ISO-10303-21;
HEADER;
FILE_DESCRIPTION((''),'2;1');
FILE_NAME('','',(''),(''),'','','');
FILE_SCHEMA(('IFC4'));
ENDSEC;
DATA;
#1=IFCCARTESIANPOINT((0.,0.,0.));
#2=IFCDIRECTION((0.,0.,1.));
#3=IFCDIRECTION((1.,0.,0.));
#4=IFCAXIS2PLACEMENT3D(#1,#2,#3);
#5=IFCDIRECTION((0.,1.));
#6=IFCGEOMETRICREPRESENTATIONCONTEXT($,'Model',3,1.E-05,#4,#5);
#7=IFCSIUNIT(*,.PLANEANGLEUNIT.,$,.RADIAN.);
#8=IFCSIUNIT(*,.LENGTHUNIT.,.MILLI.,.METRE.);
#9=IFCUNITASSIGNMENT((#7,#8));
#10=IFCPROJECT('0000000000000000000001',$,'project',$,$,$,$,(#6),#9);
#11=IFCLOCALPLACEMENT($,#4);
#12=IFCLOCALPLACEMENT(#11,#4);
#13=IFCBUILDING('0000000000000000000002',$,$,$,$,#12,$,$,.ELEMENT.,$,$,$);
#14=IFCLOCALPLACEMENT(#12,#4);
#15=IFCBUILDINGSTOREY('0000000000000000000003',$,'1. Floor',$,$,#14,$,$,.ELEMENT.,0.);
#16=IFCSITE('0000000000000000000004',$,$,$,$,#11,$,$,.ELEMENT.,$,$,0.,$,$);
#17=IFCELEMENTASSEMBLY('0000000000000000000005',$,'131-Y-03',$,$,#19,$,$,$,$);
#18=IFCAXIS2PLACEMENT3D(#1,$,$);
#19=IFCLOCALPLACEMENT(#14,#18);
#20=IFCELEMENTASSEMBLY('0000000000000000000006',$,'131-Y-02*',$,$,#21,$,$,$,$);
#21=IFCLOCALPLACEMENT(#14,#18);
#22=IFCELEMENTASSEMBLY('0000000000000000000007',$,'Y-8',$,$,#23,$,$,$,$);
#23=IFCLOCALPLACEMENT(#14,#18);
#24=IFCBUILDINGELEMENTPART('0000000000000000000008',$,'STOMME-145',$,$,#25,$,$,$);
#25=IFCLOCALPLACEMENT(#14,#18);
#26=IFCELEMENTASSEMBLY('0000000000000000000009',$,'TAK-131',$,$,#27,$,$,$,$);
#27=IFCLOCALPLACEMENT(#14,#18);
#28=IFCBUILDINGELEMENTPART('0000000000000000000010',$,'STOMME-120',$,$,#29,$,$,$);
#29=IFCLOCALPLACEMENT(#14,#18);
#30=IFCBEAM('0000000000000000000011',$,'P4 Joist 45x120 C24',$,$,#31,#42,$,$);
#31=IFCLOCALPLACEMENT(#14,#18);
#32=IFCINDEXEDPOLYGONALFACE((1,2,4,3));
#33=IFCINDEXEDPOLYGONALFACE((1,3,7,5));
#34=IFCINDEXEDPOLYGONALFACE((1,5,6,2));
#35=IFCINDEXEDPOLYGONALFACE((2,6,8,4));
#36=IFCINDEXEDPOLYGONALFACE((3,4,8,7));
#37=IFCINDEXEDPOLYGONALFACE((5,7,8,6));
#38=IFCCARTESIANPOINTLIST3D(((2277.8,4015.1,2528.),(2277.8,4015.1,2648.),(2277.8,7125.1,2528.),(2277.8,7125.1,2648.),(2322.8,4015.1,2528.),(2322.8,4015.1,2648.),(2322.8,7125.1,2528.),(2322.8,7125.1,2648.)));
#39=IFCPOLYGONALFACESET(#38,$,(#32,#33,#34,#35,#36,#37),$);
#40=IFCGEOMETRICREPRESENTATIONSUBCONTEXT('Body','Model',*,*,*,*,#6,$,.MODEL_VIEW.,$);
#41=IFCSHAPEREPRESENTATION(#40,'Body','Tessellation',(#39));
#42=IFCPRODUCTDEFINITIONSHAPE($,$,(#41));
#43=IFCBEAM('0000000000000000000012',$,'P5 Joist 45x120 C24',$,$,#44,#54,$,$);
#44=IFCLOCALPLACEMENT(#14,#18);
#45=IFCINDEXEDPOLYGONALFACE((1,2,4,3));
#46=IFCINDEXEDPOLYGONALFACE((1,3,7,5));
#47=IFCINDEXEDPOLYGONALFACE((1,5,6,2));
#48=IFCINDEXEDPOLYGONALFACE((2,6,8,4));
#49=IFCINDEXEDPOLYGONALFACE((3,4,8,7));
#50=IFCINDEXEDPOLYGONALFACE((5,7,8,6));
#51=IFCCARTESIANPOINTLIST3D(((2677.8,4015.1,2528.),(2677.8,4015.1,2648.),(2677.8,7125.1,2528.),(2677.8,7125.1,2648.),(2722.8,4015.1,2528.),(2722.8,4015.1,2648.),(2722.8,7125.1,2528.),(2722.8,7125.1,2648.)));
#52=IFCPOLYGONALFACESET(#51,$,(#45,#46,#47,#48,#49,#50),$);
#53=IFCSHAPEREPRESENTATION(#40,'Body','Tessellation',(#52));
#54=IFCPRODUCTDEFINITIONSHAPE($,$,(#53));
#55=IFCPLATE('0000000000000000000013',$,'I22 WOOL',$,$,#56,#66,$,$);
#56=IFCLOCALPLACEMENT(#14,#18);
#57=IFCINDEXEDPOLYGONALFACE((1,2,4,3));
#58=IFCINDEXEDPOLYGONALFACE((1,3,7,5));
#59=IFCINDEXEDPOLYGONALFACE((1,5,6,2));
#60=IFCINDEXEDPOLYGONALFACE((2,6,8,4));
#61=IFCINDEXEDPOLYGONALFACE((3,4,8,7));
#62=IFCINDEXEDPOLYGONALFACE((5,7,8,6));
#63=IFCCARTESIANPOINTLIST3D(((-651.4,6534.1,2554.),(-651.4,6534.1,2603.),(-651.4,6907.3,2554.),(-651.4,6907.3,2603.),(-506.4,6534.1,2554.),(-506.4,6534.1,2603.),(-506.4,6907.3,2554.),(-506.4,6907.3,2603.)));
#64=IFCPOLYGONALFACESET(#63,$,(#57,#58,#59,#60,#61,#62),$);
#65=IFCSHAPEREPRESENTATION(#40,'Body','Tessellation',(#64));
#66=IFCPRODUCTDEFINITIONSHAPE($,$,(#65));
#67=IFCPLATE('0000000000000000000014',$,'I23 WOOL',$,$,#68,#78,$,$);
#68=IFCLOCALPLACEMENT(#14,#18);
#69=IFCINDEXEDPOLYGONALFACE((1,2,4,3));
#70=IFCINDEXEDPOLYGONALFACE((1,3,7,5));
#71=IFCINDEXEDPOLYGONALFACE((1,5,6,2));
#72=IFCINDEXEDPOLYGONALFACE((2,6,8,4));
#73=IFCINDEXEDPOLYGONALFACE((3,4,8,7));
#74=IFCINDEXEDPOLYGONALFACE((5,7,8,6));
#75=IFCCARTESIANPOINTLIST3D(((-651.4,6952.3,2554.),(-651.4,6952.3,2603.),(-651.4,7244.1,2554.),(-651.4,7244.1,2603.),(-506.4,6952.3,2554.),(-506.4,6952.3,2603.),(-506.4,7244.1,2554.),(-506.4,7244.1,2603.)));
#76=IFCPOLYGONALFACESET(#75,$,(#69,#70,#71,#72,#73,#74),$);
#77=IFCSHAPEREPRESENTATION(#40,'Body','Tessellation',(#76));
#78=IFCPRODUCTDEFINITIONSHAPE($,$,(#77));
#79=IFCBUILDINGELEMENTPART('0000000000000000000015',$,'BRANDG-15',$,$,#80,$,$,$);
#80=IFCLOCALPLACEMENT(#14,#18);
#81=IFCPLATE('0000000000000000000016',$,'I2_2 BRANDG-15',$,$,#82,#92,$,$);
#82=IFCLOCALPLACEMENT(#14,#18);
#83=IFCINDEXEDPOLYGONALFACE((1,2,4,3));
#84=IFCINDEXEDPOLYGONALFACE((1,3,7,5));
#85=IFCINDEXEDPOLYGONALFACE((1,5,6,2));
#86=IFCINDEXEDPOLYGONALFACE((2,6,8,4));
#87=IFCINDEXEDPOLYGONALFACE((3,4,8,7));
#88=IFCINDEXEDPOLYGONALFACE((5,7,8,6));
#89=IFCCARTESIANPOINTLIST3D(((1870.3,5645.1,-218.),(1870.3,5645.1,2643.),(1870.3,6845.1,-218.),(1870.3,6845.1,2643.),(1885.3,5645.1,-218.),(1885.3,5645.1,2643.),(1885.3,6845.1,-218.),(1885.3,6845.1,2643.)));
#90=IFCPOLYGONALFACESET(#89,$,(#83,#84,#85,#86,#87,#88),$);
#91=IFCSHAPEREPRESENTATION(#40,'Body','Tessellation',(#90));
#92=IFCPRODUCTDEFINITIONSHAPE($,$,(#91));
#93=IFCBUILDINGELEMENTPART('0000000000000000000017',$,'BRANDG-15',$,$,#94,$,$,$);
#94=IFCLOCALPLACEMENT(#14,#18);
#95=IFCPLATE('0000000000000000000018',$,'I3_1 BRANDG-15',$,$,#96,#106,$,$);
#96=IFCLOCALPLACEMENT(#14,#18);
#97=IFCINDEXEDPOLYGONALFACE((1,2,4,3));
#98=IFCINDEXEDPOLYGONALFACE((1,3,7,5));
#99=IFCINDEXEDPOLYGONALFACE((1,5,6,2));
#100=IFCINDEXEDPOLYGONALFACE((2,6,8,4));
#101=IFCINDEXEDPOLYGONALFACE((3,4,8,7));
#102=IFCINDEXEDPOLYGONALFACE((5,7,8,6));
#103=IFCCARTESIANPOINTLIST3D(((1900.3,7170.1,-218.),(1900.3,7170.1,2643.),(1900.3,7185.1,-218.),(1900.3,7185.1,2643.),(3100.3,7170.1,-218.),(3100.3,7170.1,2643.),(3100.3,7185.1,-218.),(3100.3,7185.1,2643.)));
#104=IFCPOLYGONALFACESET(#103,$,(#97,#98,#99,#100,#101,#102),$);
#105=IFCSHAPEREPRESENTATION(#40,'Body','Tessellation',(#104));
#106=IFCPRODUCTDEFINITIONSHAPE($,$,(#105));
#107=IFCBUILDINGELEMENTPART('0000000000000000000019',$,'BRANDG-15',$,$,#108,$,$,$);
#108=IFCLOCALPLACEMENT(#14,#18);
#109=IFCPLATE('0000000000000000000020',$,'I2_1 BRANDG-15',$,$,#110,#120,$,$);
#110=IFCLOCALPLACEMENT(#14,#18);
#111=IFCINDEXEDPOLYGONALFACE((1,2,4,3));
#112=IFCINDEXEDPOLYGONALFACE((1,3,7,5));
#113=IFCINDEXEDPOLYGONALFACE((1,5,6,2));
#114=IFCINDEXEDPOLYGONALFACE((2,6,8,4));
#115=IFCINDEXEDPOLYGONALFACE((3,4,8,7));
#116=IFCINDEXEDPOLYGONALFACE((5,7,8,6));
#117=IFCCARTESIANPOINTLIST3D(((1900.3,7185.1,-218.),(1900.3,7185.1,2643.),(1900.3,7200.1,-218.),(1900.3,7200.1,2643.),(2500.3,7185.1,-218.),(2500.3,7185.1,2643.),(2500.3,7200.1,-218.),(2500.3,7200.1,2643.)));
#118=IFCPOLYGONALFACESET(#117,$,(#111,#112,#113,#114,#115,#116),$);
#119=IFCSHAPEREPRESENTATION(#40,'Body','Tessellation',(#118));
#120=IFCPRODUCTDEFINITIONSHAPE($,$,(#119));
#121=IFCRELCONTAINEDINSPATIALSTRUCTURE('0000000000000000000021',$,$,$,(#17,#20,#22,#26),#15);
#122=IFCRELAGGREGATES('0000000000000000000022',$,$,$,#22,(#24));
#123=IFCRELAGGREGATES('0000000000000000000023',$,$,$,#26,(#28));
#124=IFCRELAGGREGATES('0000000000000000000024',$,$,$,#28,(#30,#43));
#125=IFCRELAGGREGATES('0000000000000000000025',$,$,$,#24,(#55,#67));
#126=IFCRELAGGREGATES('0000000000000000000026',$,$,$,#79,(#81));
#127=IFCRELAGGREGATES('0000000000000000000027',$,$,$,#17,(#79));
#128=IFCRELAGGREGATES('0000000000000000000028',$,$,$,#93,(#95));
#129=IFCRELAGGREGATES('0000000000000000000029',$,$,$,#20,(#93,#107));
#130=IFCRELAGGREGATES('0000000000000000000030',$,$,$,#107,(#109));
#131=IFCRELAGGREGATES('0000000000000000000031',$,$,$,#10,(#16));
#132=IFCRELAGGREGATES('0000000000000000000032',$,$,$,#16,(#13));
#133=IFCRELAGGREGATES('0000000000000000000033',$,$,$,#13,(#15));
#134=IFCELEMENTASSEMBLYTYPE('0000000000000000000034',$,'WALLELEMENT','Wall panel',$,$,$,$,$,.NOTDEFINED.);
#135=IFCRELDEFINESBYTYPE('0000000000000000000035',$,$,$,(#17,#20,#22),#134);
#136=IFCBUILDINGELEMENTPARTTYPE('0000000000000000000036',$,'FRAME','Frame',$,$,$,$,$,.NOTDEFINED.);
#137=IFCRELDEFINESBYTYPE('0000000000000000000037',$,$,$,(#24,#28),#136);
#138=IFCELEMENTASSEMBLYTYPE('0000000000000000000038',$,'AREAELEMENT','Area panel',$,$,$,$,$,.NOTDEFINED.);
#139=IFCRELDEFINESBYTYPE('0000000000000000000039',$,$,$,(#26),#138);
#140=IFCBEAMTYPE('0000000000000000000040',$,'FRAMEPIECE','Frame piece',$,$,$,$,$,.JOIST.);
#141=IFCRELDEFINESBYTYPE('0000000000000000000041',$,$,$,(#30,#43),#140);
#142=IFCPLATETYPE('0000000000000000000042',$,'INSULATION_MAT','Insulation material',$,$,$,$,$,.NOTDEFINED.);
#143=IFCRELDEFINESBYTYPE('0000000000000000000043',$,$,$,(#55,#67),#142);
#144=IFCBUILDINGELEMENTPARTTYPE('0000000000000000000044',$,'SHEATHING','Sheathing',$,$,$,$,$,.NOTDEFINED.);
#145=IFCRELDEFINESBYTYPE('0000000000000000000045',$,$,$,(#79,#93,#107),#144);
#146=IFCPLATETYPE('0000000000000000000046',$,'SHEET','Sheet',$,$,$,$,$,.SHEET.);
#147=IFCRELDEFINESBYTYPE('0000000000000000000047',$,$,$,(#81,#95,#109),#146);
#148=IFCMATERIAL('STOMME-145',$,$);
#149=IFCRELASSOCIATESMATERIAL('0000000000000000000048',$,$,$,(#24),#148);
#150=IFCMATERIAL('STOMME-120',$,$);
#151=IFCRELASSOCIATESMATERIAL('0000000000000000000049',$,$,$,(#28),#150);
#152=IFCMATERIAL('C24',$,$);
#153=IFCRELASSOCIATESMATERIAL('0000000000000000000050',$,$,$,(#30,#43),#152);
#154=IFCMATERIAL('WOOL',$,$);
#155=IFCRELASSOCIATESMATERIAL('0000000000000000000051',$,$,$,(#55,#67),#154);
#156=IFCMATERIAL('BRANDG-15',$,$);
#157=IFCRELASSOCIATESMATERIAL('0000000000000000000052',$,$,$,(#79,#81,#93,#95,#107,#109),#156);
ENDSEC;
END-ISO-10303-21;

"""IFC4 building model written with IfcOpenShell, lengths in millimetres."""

from ifc_helpers import new_model, si_unit, direction, frame, origin_with_axes, origin_2d_with_axis, place, context, subcontext, project, spatial, rectangle, extrude, material, type_object, element, aggregate, save


model = new_model("IFC4")

# Units and contexts
model_context = context("Model", 3, precision=1e-05, world=origin_with_axes(), true_north=direction((0.0, 1.0)))
body_context = subcontext(model_context, "Body", "Model", "MODEL_VIEW")
ifc_project = project(units=[si_unit("PLANEANGLEUNIT", "RADIAN"), si_unit("LENGTHUNIT", "METRE", prefix="MILLI")], contexts=[model_context])

# Site, building, storey
site_placement = place(None, origin_with_axes())
site = spatial("IfcSite", under=ifc_project, at=site_placement, CompositionType="ELEMENT", RefElevation=0.0)
building_placement = place(site_placement, origin_with_axes())
building = spatial("IfcBuilding", under=site, at=building_placement, CompositionType="ELEMENT")
storey_placement = place(building_placement, origin_with_axes())
storey = spatial("IfcBuildingStorey", under=building, at=storey_placement, Name="1. Floor", CompositionType="ELEMENT", Elevation=0.0)

# Element assembly
element_assembly_type_1 = type_object("IfcElementAssemblyType", Name="WALLELEMENT", Description="Wall panel", PredefinedType="NOTDEFINED")
assembly_1_placement = place(storey_placement, origin_with_axes())
assembly_1 = element("IfcElementAssembly", 1, at=assembly_1_placement, inside=storey, type_object=element_assembly_type_1, Name="131-Y-03")
building_element_part_type_1 = type_object("IfcBuildingElementPartType", Name="FRAME", Description="Frame", PredefinedType="NOTDEFINED")
ifc_material_1 = material(Name="C24")

# Element assembly
assembly_2_placement = place(storey_placement, origin_with_axes())
assembly_2 = element("IfcElementAssembly", 2, at=assembly_2_placement, inside=storey, type_object=element_assembly_type_1, Name="131-Y-02*")

# Element assembly, building element part
assembly_3_placement = place(storey_placement, origin_with_axes())
assembly_3 = element("IfcElementAssembly", 3, at=assembly_3_placement, inside=storey, type_object=element_assembly_type_1, Name="Y-8")
ifc_material_2 = material(Name="STOMME-145")
building_element_part_1_placement = place(storey_placement, origin_with_axes())
building_element_part_1 = element("IfcBuildingElementPart", 4, at=building_element_part_1_placement, type_object=building_element_part_type_1, material=ifc_material_2, Name="STOMME-145")

aggregate(assembly_3, [building_element_part_1])

# Element assembly, building element part, beams
element_assembly_type_2 = type_object("IfcElementAssemblyType", Name="AREAELEMENT", Description="Area panel", PredefinedType="NOTDEFINED")
assembly_4_placement = place(storey_placement, origin_with_axes())
assembly_4 = element("IfcElementAssembly", 5, at=assembly_4_placement, inside=storey, type_object=element_assembly_type_2, Name="TAK-131")
ifc_material_3 = material(Name="STOMME-120")
building_element_part_2_placement = place(storey_placement, origin_with_axes())
building_element_part_2 = element("IfcBuildingElementPart", 6, at=building_element_part_2_placement, type_object=building_element_part_type_1, material=ifc_material_3, Name="STOMME-120")
aggregate(assembly_4, [building_element_part_2])
beam_type_1 = type_object("IfcBeamType", Name="FRAMEPIECE", Description="Frame piece", PredefinedType="JOIST")
beam_1_placement = place(storey_placement, frame((2300.3, 7125.1, 2588.0), z_axis=(0.0, -1.0, 0.0), x_axis=(1.0, 0.0, 0.0)))
beam_1 = element("IfcBeam", 7, at=beam_1_placement, type_object=beam_type_1, material=ifc_material_1, Name="P4 Joist 45x120 C24", context=body_context, shape_type="SweptSolid", body=[
    extrude(rectangle(XDim=45.0, YDim=120.0, at=origin_2d_with_axis()), origin_with_axes(), (0.0, 0.0, 1.0), 3110.0),
])
beam_2_placement = place(storey_placement, frame((2700.3, 7125.1, 2588.0), z_axis=(0.0, -1.0, 0.0), x_axis=(1.0, 0.0, 0.0)))
beam_2 = element("IfcBeam", 8, at=beam_2_placement, type_object=beam_type_1, material=ifc_material_1, Name="P5 Joist 45x120 C24", context=body_context, shape_type="SweptSolid", body=[
    extrude(rectangle(XDim=45.0, YDim=120.0, at=origin_2d_with_axis()), origin_with_axes(), (0.0, 0.0, 1.0), 3110.0),
])
aggregate(building_element_part_2, [beam_1, beam_2])

# Plates
ifc_material_4 = material(Name="WOOL")
plate_type_1 = type_object("IfcPlateType", Name="INSULATION_MAT", Description="Insulation material", PredefinedType="NOTDEFINED")
plate_1_placement = place(storey_placement, frame((-651.4, 6720.7, 2578.5), z_axis=(-1.0, 0.0, 0.0), x_axis=(0.0, -1.0, 0.0)))
plate_1 = element("IfcPlate", 9, at=plate_1_placement, type_object=plate_type_1, material=ifc_material_4, Name="I22 WOOL", context=body_context, shape_type="SweptSolid", body=[
    extrude(rectangle(XDim=145.0, YDim=373.2, at=origin_2d_with_axis()), frame((0.0, -24.5, -72.5), z_axis=(0.0, 1.0, 0.0), x_axis=(0.0, 0.0, 1.0)), (0.0, 0.0, 1.0), 49.0),
])
plate_2_placement = place(storey_placement, frame((-651.4, 7098.2, 2578.5), z_axis=(-1.0, 0.0, 0.0), x_axis=(0.0, -1.0, 0.0)))
plate_2 = element("IfcPlate", 10, at=plate_2_placement, type_object=plate_type_1, material=ifc_material_4, Name="I23 WOOL", context=body_context, shape_type="SweptSolid", body=[
    extrude(rectangle(XDim=145.0, YDim=291.8, at=origin_2d_with_axis()), frame((0.0, -24.5, -72.5), z_axis=(0.0, 1.0, 0.0), x_axis=(0.0, 0.0, 1.0)), (0.0, 0.0, 1.0), 49.0),
])
aggregate(building_element_part_1, [plate_1, plate_2])

# Building element part, plate
ifc_material_5 = material(Name="BRANDG-15")
building_element_part_type_2 = type_object("IfcBuildingElementPartType", Name="SHEATHING", Description="Sheathing", PredefinedType="NOTDEFINED")
building_element_part_3_placement = place(storey_placement, origin_with_axes())
building_element_part_3 = element("IfcBuildingElementPart", 11, at=building_element_part_3_placement, type_object=building_element_part_type_2, material=ifc_material_5, Name="BRANDG-15")
plate_type_2 = type_object("IfcPlateType", Name="SHEET", Description="Sheet", PredefinedType="SHEET")
plate_3_placement = place(storey_placement, frame((1870.3, 6245.1, 4782.0), z_axis=(-1.0, 0.0, 0.0), x_axis=(0.0, -1.0, 0.0)))
plate_3 = element("IfcPlate", 12, at=plate_3_placement, type_object=plate_type_2, material=ifc_material_5, Name="I2_2 BRANDG-15", context=body_context, shape_type="SweptSolid", body=[
    extrude(rectangle(XDim=15.0, YDim=1200.0, at=origin_2d_with_axis()), frame((0.0, -5000.0, -7.5), z_axis=(0.0, 1.0, 0.0), x_axis=(0.0, 0.0, 1.0)), (0.0, 0.0, 1.0), 2861.0),
])
aggregate(building_element_part_3, [plate_3])

aggregate(assembly_1, [building_element_part_3])

# Building element part, plate
building_element_part_4_placement = place(storey_placement, origin_with_axes())
building_element_part_4 = element("IfcBuildingElementPart", 13, at=building_element_part_4_placement, type_object=building_element_part_type_2, material=ifc_material_5, Name="BRANDG-15")
plate_4_placement = place(storey_placement, frame((2500.3, 7185.1, 4782.0), z_axis=(0.0, 1.0, 0.0), x_axis=(-1.0, 0.0, 0.0)))
plate_4 = element("IfcPlate", 14, at=plate_4_placement, type_object=plate_type_2, material=ifc_material_5, Name="I3_1 BRANDG-15", context=body_context, shape_type="SweptSolid", body=[
    extrude(rectangle(XDim=15.0, YDim=1200.0, at=origin_2d_with_axis()), frame((0.0, -5000.0, -7.5), z_axis=(0.0, 1.0, 0.0), x_axis=(0.0, 0.0, 1.0)), (0.0, 0.0, 1.0), 2861.0),
])
aggregate(building_element_part_4, [plate_4])

# Building element part
building_element_part_5_placement = place(storey_placement, origin_with_axes())
building_element_part_5 = element("IfcBuildingElementPart", 15, at=building_element_part_5_placement, type_object=building_element_part_type_2, material=ifc_material_5, Name="BRANDG-15")
aggregate(assembly_2, [building_element_part_4, building_element_part_5])

# Plate
plate_5_placement = place(storey_placement, frame((2500.3, 7200.1, 4782.0), z_axis=(0.0, 1.0, 0.0), x_axis=(-1.0, 0.0, 0.0)))
plate_5 = element("IfcPlate", 16, at=plate_5_placement, type_object=plate_type_2, material=ifc_material_5, Name="I2_1 BRANDG-15", context=body_context, shape_type="SweptSolid", body=[
    extrude(rectangle(XDim=15.0, YDim=600.0, at=origin_2d_with_axis()), frame((300.0, -5000.0, -7.5), z_axis=(0.0, 1.0, 0.0), x_axis=(0.0, 0.0, 1.0)), (0.0, 0.0, 1.0), 2861.0),
])
aggregate(building_element_part_5, [plate_5])

save(model, "model.ifc")
